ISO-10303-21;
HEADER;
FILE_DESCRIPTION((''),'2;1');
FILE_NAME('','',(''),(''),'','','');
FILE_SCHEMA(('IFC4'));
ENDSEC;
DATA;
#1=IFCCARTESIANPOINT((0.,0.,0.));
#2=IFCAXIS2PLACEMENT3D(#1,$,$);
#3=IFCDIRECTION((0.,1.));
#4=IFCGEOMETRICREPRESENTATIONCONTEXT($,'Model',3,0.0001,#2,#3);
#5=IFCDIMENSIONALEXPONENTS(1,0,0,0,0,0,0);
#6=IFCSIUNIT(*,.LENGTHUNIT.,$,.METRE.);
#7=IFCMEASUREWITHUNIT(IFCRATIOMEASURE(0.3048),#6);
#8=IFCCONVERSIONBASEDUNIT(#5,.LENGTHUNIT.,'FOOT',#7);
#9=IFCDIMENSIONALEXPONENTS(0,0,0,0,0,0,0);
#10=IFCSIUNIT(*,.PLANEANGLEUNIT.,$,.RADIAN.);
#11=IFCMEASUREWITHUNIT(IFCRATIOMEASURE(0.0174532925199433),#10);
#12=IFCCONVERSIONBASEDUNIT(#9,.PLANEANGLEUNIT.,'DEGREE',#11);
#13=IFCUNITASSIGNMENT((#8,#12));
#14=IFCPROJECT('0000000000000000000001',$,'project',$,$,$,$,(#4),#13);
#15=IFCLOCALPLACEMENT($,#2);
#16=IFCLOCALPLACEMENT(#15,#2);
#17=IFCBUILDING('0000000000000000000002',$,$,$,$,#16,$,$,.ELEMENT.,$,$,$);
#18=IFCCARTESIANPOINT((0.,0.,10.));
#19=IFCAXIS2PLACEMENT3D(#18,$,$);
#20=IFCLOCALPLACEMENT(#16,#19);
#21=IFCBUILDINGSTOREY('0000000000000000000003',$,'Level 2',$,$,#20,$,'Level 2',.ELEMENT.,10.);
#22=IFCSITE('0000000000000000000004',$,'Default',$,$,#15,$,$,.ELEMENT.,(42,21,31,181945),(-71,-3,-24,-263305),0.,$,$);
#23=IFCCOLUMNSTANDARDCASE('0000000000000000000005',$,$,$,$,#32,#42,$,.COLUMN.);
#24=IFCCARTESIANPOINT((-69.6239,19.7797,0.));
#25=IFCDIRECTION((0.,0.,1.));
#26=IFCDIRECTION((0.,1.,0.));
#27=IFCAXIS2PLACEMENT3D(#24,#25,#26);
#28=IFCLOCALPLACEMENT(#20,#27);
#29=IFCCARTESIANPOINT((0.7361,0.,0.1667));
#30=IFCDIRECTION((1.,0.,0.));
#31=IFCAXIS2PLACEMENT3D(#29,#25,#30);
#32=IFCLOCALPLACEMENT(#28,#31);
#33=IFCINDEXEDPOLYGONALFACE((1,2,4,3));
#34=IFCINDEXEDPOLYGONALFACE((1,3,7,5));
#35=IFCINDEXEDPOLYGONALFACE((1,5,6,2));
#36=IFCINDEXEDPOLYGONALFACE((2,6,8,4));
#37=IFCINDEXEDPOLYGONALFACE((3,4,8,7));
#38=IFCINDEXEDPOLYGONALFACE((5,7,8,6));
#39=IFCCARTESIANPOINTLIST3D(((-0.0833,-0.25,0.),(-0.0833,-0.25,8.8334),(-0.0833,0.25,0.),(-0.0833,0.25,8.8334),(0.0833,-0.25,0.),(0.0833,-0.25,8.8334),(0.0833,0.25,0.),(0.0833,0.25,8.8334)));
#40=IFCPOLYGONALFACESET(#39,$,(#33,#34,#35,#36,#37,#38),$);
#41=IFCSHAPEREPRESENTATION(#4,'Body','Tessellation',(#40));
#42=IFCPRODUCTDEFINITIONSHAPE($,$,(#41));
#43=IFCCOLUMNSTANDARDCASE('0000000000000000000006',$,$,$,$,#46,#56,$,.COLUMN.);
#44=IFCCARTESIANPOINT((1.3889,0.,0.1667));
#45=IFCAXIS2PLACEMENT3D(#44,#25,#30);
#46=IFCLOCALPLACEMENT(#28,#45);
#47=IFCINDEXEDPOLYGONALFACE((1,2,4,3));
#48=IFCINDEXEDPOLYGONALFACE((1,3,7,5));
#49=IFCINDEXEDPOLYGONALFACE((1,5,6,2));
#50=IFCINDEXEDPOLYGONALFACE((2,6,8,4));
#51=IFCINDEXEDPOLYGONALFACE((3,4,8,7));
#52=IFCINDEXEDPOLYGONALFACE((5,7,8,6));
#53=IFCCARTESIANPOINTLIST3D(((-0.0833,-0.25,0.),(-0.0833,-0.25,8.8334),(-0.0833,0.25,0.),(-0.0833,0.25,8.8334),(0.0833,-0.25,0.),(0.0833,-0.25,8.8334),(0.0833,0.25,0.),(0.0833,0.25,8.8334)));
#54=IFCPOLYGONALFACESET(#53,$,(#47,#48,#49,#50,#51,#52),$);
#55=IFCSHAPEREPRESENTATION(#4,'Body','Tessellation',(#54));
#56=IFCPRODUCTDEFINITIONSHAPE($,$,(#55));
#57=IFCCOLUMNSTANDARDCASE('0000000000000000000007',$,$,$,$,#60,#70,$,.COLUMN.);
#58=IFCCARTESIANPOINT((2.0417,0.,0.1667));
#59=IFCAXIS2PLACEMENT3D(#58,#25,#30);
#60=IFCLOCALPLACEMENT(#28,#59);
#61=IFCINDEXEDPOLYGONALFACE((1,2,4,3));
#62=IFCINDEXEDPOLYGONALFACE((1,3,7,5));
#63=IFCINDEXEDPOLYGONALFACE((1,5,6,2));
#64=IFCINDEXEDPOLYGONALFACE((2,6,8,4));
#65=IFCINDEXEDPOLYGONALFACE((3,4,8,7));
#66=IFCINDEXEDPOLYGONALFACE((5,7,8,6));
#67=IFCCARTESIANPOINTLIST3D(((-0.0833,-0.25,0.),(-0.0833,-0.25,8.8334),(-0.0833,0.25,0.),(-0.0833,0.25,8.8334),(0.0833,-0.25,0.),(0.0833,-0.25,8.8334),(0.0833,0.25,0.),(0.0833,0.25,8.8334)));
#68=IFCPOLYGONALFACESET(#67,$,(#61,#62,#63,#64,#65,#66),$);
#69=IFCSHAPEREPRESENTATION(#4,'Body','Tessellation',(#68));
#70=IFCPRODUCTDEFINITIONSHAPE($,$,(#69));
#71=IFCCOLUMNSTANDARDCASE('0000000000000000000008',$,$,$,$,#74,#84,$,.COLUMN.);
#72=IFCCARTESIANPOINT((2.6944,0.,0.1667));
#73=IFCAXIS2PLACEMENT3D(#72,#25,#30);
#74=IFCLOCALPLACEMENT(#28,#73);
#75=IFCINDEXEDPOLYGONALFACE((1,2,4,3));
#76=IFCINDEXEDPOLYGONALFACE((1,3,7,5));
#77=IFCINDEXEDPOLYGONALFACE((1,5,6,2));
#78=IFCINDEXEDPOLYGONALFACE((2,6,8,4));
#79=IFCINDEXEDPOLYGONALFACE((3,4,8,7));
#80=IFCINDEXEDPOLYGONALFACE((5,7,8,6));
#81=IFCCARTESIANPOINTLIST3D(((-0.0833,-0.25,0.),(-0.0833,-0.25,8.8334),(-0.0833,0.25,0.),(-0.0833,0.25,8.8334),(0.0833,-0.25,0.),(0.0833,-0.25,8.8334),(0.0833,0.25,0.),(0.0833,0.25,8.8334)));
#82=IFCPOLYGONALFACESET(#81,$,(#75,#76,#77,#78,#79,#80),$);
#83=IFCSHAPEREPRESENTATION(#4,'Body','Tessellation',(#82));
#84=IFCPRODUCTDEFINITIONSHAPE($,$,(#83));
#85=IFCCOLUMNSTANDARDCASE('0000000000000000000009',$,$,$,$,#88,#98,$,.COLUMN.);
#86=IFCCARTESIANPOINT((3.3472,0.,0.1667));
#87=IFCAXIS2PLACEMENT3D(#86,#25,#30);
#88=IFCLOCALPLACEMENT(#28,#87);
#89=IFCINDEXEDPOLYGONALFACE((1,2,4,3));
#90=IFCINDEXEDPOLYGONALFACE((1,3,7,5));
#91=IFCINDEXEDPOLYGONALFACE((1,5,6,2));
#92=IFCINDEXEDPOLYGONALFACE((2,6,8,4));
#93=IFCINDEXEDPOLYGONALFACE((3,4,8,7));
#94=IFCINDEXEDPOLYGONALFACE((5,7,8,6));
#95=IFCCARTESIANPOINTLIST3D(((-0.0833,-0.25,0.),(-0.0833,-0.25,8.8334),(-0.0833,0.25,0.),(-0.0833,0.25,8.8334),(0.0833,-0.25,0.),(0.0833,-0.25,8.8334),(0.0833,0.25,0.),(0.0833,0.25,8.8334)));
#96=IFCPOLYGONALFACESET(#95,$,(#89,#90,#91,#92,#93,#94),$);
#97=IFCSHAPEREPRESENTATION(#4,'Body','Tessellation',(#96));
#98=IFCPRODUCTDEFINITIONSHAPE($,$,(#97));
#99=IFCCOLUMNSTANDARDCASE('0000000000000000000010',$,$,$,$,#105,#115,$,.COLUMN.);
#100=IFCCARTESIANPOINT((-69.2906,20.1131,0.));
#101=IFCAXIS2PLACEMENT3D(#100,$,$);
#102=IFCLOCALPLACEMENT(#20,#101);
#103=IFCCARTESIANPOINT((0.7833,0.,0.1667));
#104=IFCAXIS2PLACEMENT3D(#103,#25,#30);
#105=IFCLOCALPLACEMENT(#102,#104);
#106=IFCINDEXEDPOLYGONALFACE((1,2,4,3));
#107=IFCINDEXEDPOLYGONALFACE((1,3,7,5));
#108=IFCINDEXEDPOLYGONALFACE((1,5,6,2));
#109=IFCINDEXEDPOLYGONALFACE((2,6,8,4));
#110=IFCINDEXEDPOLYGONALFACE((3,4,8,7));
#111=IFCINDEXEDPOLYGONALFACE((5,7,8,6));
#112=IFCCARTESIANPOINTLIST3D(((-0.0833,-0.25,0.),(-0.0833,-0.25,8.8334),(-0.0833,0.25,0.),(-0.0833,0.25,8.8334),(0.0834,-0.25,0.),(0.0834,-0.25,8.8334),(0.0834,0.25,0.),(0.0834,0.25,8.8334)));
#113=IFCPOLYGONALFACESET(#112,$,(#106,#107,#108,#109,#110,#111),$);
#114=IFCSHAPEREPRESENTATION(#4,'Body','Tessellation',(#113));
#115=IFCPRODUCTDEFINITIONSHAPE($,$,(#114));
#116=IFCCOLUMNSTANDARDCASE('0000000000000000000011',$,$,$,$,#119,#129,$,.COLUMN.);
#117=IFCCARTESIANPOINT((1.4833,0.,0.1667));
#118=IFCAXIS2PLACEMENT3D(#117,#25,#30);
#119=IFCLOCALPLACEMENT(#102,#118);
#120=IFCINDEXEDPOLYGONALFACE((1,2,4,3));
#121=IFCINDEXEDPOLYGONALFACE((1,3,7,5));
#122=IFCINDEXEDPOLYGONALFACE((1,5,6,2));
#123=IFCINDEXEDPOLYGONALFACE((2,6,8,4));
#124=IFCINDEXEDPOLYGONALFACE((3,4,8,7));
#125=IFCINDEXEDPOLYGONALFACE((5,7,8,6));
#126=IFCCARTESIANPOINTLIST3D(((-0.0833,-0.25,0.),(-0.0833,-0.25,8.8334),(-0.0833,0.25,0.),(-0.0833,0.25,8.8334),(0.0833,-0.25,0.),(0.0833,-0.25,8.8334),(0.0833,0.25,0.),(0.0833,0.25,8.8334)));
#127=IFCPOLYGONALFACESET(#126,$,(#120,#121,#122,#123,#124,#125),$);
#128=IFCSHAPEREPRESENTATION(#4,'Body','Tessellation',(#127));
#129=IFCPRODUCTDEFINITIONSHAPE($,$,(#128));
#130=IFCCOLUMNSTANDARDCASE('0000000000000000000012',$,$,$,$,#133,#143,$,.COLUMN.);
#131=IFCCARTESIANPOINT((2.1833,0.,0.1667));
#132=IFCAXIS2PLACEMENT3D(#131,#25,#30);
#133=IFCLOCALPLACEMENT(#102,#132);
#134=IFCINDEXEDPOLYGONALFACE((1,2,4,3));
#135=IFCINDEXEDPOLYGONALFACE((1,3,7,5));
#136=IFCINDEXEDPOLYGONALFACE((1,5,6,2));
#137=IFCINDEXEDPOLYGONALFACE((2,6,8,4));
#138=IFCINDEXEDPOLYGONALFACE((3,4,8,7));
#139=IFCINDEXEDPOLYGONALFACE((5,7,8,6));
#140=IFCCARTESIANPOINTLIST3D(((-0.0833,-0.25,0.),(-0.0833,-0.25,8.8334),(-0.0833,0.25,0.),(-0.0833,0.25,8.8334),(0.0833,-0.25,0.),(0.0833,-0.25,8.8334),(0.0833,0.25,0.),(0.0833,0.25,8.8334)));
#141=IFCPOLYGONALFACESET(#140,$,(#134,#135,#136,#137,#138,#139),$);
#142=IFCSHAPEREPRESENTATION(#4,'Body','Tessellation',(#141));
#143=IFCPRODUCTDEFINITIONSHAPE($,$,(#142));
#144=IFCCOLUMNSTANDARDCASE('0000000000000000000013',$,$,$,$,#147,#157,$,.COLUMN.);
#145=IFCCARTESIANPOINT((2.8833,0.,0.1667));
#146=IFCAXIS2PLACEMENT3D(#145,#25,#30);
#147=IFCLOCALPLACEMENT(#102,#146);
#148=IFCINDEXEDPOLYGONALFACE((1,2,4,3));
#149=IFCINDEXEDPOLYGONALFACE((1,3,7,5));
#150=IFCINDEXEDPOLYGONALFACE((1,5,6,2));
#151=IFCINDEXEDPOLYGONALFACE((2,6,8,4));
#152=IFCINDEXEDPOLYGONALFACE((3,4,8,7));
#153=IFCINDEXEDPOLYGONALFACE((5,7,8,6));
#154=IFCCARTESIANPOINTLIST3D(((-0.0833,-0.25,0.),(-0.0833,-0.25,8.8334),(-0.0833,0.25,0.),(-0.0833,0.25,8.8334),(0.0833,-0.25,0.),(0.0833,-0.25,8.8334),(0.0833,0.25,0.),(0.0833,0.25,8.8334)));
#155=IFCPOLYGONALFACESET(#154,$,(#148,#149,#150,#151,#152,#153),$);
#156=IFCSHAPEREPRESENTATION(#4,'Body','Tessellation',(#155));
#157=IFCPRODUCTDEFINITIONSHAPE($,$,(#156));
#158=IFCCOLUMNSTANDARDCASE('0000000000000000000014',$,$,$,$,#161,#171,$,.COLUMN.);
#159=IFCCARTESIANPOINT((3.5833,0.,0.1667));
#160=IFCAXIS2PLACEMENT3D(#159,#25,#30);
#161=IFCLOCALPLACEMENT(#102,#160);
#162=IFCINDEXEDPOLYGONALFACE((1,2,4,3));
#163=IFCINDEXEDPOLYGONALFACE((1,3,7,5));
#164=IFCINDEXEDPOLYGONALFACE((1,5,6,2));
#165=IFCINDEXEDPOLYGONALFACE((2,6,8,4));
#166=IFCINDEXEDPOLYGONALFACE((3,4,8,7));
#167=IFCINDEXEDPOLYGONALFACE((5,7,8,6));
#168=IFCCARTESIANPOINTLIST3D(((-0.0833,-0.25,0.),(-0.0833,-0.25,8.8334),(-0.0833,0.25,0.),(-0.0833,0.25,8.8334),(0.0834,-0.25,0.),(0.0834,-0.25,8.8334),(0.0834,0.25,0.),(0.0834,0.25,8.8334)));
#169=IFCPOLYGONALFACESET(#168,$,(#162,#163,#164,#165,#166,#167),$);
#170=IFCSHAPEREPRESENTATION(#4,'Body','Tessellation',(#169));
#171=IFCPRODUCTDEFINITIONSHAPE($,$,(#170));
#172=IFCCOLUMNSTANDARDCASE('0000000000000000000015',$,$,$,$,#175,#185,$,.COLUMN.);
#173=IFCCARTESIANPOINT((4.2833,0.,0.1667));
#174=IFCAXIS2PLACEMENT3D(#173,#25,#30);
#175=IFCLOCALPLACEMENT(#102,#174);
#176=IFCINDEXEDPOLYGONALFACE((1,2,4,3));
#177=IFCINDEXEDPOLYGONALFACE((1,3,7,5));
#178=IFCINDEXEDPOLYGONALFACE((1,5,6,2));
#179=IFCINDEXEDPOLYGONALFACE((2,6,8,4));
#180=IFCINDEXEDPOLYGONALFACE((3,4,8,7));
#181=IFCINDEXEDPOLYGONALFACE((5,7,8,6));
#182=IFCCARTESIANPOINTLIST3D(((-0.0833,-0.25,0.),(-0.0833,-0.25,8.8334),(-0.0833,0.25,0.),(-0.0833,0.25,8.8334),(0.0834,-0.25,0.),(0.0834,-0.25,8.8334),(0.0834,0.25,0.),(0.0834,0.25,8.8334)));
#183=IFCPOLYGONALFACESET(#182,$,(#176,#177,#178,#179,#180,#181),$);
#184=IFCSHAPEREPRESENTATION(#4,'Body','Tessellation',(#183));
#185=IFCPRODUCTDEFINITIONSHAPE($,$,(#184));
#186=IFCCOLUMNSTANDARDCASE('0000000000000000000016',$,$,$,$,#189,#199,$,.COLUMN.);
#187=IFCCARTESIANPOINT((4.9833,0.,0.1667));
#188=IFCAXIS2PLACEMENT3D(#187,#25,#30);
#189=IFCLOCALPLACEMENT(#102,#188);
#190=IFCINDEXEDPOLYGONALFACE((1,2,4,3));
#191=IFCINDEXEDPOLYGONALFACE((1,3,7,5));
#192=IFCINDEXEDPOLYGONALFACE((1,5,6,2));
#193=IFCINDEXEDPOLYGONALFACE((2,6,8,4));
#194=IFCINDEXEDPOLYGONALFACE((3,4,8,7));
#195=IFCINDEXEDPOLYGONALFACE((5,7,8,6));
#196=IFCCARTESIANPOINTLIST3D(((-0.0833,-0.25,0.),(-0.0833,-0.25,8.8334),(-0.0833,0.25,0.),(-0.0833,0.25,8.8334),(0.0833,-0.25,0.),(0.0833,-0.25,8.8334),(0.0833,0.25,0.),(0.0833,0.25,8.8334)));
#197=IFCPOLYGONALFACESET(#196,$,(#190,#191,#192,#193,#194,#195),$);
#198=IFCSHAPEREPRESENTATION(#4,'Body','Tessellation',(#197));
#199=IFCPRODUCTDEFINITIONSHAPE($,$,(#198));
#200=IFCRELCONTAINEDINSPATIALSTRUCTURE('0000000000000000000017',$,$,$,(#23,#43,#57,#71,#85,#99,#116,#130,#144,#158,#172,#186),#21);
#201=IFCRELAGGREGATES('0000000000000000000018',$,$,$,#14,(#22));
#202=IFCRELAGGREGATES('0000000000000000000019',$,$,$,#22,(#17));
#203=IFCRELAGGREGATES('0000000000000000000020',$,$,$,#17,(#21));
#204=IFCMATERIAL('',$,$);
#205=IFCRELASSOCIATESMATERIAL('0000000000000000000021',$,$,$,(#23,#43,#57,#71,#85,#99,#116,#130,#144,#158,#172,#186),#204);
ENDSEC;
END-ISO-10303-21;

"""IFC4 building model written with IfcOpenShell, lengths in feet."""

from ifc_helpers import new_model, entity, si_unit, converted_unit, direction, frame, origin, place, context, project, spatial, rectangle, extrude, material, element, save


model = new_model("IFC4")

# Units and contexts
model_context = context("Model", 3, precision=0.0001, world=origin(), true_north=direction((0.0, 1.0)))
ifc_project = project(units=[converted_unit("LENGTHUNIT", "FOOT", entity("IfcRatioMeasure", 0.3048), si_unit("LENGTHUNIT", "METRE"), dimensions=[1, 0, 0, 0, 0, 0, 0]), converted_unit("PLANEANGLEUNIT", "DEGREE", entity("IfcRatioMeasure", 0.0174532925199433), si_unit("PLANEANGLEUNIT", "RADIAN"), dimensions=[0, 0, 0, 0, 0, 0, 0])], contexts=[model_context])

# Site, building, storey
site_placement = place(None, origin())
site = spatial("IfcSite", under=ifc_project, at=site_placement, Name="Default", CompositionType="ELEMENT", RefLatitude=(42, 21, 31, 181945), RefLongitude=(-71, -3, -24, -263305), RefElevation=0.0)
building_placement = place(site_placement, origin())
building = spatial("IfcBuilding", under=site, at=building_placement, CompositionType="ELEMENT")
storey_placement = place(building_placement, frame((0.0, 0.0, 10.0)))
storey = spatial("IfcBuildingStorey", under=building, at=storey_placement, Name="Level 2", LongName="Level 2", CompositionType="ELEMENT", Elevation=10.0)

# Columns
ifc_material_1 = material(Name="")
placement_1 = place(storey_placement, frame((-69.6239, 19.7797, 0.0), z_axis=(0.0, 0.0, 1.0), x_axis=(0.0, 1.0, 0.0)))
for number, where, z_axis, x_axis in (
    (1, (0.7361, 0.0, 0.1667), (0.0, 0.0, 1.0), (1.0, 0.0, 0.0)),
    (2, (1.3889, 0.0, 0.1667), (0.0, 0.0, 1.0), (1.0, 0.0, 0.0)),
    (3, (2.0417, 0.0, 0.1667), (0.0, 0.0, 1.0), (1.0, 0.0, 0.0)),
    (4, (2.6944, 0.0, 0.1667), (0.0, 0.0, 1.0), (1.0, 0.0, 0.0)),
    (5, (3.3472, 0.0, 0.1667), (0.0, 0.0, 1.0), (1.0, 0.0, 0.0)),
):
    element("IfcColumnStandardCase", number, at=place(placement_1, frame(where, z_axis=z_axis, x_axis=x_axis)), inside=storey, material=ifc_material_1, PredefinedType="COLUMN", context=model_context, shape_type="SweptSolid", body=[
        extrude(rectangle(XDim=0.1667, YDim=0.5), origin(), (0.0, 0.0, 1.0), 8.8334),
    ])
placement_2 = place(storey_placement, frame((-69.2906, 20.1131, 0.0)))
for number, where, z_axis, x_axis in (
    (6, (0.7833, 0.0, 0.1667), (0.0, 0.0, 1.0), (1.0, 0.0, 0.0)),
    (7, (1.4833, 0.0, 0.1667), (0.0, 0.0, 1.0), (1.0, 0.0, 0.0)),
    (8, (2.1833, 0.0, 0.1667), (0.0, 0.0, 1.0), (1.0, 0.0, 0.0)),
    (9, (2.8833, 0.0, 0.1667), (0.0, 0.0, 1.0), (1.0, 0.0, 0.0)),
    (10, (3.5833, 0.0, 0.1667), (0.0, 0.0, 1.0), (1.0, 0.0, 0.0)),
    (11, (4.2833, 0.0, 0.1667), (0.0, 0.0, 1.0), (1.0, 0.0, 0.0)),
    (12, (4.9833, 0.0, 0.1667), (0.0, 0.0, 1.0), (1.0, 0.0, 0.0)),
):
    element("IfcColumnStandardCase", number, at=place(placement_2, frame(where, z_axis=z_axis, x_axis=x_axis)), inside=storey, material=ifc_material_1, PredefinedType="COLUMN", context=model_context, shape_type="SweptSolid", body=[
        extrude(rectangle(XDim=0.1667, YDim=0.5), origin(), (0.0, 0.0, 1.0), 8.8334),
    ])

save(model, "model.ifc")
